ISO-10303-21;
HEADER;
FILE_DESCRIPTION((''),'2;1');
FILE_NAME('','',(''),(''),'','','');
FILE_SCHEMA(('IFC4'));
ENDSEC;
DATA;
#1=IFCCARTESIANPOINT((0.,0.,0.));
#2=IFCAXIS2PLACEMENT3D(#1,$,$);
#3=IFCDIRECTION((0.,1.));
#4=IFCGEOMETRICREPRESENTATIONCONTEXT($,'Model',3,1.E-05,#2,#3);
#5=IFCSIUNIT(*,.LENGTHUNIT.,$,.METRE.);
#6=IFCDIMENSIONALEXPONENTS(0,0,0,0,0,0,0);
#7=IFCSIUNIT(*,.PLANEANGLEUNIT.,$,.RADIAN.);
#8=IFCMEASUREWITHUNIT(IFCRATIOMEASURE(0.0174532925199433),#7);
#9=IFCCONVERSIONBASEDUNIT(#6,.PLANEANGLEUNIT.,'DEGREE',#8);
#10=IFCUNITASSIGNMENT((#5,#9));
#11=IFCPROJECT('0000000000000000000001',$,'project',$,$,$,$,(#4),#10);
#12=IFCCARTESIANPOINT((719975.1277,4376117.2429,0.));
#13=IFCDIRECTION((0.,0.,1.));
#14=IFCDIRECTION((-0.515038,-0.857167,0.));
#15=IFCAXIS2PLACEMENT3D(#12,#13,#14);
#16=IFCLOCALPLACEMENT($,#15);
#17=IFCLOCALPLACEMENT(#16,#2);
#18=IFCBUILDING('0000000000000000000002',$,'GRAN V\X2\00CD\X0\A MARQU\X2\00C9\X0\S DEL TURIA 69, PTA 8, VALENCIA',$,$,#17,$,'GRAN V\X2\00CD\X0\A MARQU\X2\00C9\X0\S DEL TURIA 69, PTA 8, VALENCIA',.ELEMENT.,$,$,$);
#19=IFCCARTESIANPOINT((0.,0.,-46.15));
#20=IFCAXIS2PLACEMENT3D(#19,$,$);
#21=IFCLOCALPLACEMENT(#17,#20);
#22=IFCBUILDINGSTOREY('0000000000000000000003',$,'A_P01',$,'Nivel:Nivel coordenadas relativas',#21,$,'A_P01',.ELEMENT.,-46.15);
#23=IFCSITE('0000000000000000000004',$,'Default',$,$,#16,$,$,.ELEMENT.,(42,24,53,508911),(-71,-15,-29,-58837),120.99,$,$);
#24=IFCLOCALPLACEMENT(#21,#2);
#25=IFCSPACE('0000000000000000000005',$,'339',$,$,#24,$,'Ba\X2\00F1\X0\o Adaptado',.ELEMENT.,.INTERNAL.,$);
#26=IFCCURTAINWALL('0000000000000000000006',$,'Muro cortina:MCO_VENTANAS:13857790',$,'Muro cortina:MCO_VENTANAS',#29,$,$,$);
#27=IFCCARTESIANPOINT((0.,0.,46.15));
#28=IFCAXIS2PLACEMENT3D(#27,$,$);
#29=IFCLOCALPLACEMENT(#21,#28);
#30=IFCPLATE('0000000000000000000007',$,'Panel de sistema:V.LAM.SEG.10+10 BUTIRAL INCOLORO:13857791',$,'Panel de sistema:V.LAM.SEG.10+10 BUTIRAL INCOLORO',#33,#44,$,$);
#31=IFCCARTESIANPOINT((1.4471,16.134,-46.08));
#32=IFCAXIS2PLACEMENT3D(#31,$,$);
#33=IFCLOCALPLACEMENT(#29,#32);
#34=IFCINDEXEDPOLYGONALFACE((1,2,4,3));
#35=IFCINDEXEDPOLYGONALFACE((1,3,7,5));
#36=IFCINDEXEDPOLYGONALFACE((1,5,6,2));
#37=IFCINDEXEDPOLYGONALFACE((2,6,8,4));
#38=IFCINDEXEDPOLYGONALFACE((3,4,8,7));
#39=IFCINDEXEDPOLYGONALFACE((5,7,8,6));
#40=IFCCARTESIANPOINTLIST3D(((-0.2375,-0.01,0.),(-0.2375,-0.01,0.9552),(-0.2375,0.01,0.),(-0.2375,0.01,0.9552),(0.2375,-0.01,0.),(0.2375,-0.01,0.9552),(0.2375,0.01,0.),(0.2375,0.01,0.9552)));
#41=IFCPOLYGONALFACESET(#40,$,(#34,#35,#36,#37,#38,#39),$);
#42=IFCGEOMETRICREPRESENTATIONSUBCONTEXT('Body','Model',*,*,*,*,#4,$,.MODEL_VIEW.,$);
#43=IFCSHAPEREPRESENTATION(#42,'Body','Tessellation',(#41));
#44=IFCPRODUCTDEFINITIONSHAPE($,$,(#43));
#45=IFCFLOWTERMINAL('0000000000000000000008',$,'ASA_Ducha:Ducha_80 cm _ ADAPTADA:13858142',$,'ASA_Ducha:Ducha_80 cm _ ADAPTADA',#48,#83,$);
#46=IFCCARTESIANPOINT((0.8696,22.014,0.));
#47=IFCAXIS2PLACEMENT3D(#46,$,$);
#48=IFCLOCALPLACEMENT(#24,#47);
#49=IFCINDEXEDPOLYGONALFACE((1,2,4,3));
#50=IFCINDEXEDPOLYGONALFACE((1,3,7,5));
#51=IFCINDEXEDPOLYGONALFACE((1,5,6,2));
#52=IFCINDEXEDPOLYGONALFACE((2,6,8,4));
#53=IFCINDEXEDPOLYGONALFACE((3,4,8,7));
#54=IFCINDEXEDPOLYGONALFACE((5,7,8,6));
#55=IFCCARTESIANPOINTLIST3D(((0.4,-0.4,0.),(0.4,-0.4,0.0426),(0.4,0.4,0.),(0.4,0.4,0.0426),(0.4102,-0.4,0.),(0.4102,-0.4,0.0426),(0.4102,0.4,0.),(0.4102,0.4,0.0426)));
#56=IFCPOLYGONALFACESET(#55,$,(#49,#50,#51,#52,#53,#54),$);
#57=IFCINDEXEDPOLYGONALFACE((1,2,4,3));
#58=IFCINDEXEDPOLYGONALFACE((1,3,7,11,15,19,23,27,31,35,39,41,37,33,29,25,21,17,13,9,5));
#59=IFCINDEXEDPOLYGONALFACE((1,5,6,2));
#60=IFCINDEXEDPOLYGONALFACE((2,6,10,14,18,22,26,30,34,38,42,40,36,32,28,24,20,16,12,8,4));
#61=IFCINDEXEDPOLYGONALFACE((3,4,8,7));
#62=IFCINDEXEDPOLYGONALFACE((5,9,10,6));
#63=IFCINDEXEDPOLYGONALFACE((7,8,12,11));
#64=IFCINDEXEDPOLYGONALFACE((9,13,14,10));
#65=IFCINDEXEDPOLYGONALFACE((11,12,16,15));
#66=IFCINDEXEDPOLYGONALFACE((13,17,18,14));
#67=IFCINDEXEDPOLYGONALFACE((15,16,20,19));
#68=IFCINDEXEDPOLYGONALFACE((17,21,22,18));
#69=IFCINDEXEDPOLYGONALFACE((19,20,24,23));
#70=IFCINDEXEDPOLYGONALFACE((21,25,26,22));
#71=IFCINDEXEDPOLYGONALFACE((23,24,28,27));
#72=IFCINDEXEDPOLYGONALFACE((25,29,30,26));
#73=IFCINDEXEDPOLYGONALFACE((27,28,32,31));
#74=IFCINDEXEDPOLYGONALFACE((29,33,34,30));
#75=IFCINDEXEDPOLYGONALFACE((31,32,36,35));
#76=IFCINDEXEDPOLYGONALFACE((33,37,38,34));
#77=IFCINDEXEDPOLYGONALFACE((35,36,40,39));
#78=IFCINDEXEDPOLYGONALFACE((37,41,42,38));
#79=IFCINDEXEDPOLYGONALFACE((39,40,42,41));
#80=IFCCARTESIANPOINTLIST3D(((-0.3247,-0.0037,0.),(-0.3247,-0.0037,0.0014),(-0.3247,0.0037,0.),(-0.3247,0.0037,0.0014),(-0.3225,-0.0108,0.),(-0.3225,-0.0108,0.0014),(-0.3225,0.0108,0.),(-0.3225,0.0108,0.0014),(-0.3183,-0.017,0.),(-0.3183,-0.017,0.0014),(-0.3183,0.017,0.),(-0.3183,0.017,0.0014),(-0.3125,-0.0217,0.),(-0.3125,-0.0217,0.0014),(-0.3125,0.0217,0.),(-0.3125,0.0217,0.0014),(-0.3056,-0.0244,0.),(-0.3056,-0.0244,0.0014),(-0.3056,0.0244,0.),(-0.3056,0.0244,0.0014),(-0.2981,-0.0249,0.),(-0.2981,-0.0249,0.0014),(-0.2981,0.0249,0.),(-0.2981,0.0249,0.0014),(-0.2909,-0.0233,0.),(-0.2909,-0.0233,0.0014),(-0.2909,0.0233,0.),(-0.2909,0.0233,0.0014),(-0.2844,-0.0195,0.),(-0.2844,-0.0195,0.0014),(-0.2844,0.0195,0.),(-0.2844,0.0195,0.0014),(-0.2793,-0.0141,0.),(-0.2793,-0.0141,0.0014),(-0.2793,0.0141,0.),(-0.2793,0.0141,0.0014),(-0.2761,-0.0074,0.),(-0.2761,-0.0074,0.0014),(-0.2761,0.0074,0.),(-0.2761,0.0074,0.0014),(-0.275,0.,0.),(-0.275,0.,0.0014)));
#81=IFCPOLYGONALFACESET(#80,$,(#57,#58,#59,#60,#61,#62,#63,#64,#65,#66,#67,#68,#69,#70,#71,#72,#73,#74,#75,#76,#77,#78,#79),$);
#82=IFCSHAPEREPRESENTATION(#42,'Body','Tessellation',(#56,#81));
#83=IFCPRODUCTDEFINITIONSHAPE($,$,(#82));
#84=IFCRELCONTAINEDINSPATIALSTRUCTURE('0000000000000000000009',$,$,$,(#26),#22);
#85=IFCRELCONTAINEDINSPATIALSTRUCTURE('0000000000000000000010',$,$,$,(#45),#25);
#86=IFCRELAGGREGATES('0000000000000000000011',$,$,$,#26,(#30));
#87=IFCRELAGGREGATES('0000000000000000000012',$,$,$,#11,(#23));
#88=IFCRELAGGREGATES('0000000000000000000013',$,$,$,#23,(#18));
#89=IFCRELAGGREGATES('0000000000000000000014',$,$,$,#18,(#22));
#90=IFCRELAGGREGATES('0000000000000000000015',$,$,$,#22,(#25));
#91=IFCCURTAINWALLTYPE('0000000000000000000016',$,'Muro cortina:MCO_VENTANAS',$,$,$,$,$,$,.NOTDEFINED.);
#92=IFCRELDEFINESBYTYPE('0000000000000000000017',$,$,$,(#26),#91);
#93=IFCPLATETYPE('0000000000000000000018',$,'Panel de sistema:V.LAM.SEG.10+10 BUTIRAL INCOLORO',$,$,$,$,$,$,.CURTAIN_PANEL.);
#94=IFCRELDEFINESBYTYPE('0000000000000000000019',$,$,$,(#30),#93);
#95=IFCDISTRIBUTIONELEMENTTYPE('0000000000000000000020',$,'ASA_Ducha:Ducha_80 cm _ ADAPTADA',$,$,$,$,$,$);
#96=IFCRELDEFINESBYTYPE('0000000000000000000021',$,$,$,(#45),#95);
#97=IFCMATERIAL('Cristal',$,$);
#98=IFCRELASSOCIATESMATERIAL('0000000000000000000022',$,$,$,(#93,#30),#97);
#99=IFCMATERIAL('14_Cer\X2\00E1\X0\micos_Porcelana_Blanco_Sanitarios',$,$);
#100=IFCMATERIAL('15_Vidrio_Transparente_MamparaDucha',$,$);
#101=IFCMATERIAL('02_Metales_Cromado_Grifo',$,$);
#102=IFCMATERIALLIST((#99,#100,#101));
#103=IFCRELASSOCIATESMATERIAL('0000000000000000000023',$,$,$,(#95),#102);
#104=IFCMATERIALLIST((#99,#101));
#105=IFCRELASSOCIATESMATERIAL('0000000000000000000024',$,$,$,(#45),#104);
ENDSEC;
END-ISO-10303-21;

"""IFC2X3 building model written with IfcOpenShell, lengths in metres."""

from ifc_helpers import new_model, entity, si_unit, converted_unit, direction, frame, frame_2d, origin, origin_2d_with_axis, place, context, subcontext, project, spatial, rectangle, circle, extrude, source, transform, mapped, material, material_list, type_object, type_shapes, element, aggregate, save


model = new_model("IFC2X3")

# Units and contexts
model_context = context("Model", 3, precision=1e-05, world=origin(), true_north=direction((0.0, 1.0)))
body_context = subcontext(model_context, "Body", "Model", "MODEL_VIEW")
ifc_project = project(units=[si_unit("LENGTHUNIT", "METRE"), converted_unit("PLANEANGLEUNIT", "DEGREE", entity("IfcRatioMeasure", 0.0174532925199433), si_unit("PLANEANGLEUNIT", "RADIAN"), dimensions=[0, 0, 0, 0, 0, 0, 0])], contexts=[model_context])

# Site, building, storey
site_placement = place(None, frame((719975.1277, 4376117.2429, 0.0), z_axis=(0.0, 0.0, 1.0), x_axis=(-0.515038, -0.857167, 0.0)))
site = spatial("IfcSite", under=ifc_project, at=site_placement, Name="Default", CompositionType="ELEMENT", RefLatitude=(42, 24, 53, 508911), RefLongitude=(-71, -15, -29, -58837), RefElevation=120.99)
building_placement = place(site_placement, origin())
building = spatial("IfcBuilding", under=site, at=building_placement, Name="GRAN VÍA MARQUÉS DEL TURIA 69, PTA 8, VALENCIA", LongName="GRAN VÍA MARQUÉS DEL TURIA 69, PTA 8, VALENCIA", CompositionType="ELEMENT")
storey_placement = place(building_placement, frame((0.0, 0.0, -46.15)))
storey = spatial("IfcBuildingStorey", under=building, at=storey_placement, Name="A_P01", ObjectType="Nivel:Nivel coordenadas relativas", LongName="A_P01", CompositionType="ELEMENT", Elevation=-46.15)

# Curtain wall, plate
curtain_wall_type = type_object("IfcCurtainWallType", Name="Muro cortina:MCO_VENTANAS", PredefinedType="NOTDEFINED")
curtain_wall_placement = place(storey_placement, frame((0.0, 0.0, 46.15)))
curtain_wall = element("IfcCurtainWall", 1, at=curtain_wall_placement, inside=storey, type_object=curtain_wall_type, Name="Muro cortina:MCO_VENTANAS:13857790", ObjectType="Muro cortina:MCO_VENTANAS")
ifc_material_1 = material(Name="Cristal")
plate_type_1 = type_object("IfcPlateType", Name="Panel de sistema:V.LAM.SEG.10+10 BUTIRAL INCOLORO", PredefinedType="CURTAIN_PANEL", material=ifc_material_1)
shared_shape_1 = source(origin(), body_context, "Body", "SweptSolid", [
    extrude(rectangle(XDim=0.02, YDim=0.475, at=frame_2d((0.0, 0.0), x_axis=(1.0, 0.0))), frame((0.0, 0.0, 0.0), z_axis=(0.0, 0.0, 1.0), x_axis=(0.0, 1.0, 0.0)), (0.0, 0.0, 1.0), 0.9552),
])
type_shapes(plate_type_1, [shared_shape_1])
plate_1_placement = place(curtain_wall_placement, frame((1.4471, 16.134, -46.08)))
plate_1 = element("IfcPlate", 2, at=plate_1_placement, type_object=plate_type_1, material=ifc_material_1, Name="Panel de sistema:V.LAM.SEG.10+10 BUTIRAL INCOLORO:13857791", ObjectType="Panel de sistema:V.LAM.SEG.10+10 BUTIRAL INCOLORO", context=body_context, shape_type="MappedRepresentation", body=[
    mapped(shared_shape_1, transform((0.0, 0.0, 0.0), scale=1.0)),
])
aggregate(curtain_wall, [plate_1])

# Shared definitions
space_1_placement = place(storey_placement, origin())
space_1 = spatial("IfcSpace", under=storey, at=space_1_placement, Name="339", LongName="Baño Adaptado", CompositionType="ELEMENT", InteriorOrExteriorSpace="INTERNAL")

# Flow terminal
ifc_material_2 = material(Name="14_Cerámicos_Porcelana_Blanco_Sanitarios")
ifc_material_3 = material(Name="02_Metales_Cromado_Grifo")
ifc_material_list_1 = material_list([ifc_material_2, ifc_material_3])
ifc_material_4 = material(Name="15_Vidrio_Transparente_MamparaDucha")
ifc_material_list_2 = material_list([ifc_material_2, ifc_material_4, ifc_material_3])
distribution_element_type_1 = type_object("IfcDistributionElementType", Name="ASA_Ducha:Ducha_80 cm _ ADAPTADA", material=ifc_material_list_2)
shared_shape_2 = source(origin(), body_context, "Body", "SweptSolid", [
    extrude(rectangle(XDim=0.8, YDim=0.0102, at=origin_2d_with_axis()), frame((0.4051, 0.0, 0.0), z_axis=(0.0, 0.0, 1.0), x_axis=(0.0, 1.0, 0.0)), (0.0, 0.0, 1.0), 0.0426),
    extrude(circle(Radius=0.025, at=frame_2d((0.0, 0.0), x_axis=(1.0, 0.0))), frame((-0.3, 0.0, 0.0)), (0.0, 0.0, 1.0), 0.0014),
])
type_shapes(distribution_element_type_1, [shared_shape_2])
flow_terminal_1_placement = place(space_1_placement, frame((0.8696, 22.014, 0.0)))
element("IfcFlowTerminal", 3, at=flow_terminal_1_placement, inside=space_1, type_object=distribution_element_type_1, material=ifc_material_list_1, Name="ASA_Ducha:Ducha_80 cm _ ADAPTADA:13858142", ObjectType="ASA_Ducha:Ducha_80 cm _ ADAPTADA", context=body_context, shape_type="MappedRepresentation", body=[
    mapped(shared_shape_2, transform((0.0, 0.0, 0.0), scale=1.0)),
])

save(model, "model.ifc")
